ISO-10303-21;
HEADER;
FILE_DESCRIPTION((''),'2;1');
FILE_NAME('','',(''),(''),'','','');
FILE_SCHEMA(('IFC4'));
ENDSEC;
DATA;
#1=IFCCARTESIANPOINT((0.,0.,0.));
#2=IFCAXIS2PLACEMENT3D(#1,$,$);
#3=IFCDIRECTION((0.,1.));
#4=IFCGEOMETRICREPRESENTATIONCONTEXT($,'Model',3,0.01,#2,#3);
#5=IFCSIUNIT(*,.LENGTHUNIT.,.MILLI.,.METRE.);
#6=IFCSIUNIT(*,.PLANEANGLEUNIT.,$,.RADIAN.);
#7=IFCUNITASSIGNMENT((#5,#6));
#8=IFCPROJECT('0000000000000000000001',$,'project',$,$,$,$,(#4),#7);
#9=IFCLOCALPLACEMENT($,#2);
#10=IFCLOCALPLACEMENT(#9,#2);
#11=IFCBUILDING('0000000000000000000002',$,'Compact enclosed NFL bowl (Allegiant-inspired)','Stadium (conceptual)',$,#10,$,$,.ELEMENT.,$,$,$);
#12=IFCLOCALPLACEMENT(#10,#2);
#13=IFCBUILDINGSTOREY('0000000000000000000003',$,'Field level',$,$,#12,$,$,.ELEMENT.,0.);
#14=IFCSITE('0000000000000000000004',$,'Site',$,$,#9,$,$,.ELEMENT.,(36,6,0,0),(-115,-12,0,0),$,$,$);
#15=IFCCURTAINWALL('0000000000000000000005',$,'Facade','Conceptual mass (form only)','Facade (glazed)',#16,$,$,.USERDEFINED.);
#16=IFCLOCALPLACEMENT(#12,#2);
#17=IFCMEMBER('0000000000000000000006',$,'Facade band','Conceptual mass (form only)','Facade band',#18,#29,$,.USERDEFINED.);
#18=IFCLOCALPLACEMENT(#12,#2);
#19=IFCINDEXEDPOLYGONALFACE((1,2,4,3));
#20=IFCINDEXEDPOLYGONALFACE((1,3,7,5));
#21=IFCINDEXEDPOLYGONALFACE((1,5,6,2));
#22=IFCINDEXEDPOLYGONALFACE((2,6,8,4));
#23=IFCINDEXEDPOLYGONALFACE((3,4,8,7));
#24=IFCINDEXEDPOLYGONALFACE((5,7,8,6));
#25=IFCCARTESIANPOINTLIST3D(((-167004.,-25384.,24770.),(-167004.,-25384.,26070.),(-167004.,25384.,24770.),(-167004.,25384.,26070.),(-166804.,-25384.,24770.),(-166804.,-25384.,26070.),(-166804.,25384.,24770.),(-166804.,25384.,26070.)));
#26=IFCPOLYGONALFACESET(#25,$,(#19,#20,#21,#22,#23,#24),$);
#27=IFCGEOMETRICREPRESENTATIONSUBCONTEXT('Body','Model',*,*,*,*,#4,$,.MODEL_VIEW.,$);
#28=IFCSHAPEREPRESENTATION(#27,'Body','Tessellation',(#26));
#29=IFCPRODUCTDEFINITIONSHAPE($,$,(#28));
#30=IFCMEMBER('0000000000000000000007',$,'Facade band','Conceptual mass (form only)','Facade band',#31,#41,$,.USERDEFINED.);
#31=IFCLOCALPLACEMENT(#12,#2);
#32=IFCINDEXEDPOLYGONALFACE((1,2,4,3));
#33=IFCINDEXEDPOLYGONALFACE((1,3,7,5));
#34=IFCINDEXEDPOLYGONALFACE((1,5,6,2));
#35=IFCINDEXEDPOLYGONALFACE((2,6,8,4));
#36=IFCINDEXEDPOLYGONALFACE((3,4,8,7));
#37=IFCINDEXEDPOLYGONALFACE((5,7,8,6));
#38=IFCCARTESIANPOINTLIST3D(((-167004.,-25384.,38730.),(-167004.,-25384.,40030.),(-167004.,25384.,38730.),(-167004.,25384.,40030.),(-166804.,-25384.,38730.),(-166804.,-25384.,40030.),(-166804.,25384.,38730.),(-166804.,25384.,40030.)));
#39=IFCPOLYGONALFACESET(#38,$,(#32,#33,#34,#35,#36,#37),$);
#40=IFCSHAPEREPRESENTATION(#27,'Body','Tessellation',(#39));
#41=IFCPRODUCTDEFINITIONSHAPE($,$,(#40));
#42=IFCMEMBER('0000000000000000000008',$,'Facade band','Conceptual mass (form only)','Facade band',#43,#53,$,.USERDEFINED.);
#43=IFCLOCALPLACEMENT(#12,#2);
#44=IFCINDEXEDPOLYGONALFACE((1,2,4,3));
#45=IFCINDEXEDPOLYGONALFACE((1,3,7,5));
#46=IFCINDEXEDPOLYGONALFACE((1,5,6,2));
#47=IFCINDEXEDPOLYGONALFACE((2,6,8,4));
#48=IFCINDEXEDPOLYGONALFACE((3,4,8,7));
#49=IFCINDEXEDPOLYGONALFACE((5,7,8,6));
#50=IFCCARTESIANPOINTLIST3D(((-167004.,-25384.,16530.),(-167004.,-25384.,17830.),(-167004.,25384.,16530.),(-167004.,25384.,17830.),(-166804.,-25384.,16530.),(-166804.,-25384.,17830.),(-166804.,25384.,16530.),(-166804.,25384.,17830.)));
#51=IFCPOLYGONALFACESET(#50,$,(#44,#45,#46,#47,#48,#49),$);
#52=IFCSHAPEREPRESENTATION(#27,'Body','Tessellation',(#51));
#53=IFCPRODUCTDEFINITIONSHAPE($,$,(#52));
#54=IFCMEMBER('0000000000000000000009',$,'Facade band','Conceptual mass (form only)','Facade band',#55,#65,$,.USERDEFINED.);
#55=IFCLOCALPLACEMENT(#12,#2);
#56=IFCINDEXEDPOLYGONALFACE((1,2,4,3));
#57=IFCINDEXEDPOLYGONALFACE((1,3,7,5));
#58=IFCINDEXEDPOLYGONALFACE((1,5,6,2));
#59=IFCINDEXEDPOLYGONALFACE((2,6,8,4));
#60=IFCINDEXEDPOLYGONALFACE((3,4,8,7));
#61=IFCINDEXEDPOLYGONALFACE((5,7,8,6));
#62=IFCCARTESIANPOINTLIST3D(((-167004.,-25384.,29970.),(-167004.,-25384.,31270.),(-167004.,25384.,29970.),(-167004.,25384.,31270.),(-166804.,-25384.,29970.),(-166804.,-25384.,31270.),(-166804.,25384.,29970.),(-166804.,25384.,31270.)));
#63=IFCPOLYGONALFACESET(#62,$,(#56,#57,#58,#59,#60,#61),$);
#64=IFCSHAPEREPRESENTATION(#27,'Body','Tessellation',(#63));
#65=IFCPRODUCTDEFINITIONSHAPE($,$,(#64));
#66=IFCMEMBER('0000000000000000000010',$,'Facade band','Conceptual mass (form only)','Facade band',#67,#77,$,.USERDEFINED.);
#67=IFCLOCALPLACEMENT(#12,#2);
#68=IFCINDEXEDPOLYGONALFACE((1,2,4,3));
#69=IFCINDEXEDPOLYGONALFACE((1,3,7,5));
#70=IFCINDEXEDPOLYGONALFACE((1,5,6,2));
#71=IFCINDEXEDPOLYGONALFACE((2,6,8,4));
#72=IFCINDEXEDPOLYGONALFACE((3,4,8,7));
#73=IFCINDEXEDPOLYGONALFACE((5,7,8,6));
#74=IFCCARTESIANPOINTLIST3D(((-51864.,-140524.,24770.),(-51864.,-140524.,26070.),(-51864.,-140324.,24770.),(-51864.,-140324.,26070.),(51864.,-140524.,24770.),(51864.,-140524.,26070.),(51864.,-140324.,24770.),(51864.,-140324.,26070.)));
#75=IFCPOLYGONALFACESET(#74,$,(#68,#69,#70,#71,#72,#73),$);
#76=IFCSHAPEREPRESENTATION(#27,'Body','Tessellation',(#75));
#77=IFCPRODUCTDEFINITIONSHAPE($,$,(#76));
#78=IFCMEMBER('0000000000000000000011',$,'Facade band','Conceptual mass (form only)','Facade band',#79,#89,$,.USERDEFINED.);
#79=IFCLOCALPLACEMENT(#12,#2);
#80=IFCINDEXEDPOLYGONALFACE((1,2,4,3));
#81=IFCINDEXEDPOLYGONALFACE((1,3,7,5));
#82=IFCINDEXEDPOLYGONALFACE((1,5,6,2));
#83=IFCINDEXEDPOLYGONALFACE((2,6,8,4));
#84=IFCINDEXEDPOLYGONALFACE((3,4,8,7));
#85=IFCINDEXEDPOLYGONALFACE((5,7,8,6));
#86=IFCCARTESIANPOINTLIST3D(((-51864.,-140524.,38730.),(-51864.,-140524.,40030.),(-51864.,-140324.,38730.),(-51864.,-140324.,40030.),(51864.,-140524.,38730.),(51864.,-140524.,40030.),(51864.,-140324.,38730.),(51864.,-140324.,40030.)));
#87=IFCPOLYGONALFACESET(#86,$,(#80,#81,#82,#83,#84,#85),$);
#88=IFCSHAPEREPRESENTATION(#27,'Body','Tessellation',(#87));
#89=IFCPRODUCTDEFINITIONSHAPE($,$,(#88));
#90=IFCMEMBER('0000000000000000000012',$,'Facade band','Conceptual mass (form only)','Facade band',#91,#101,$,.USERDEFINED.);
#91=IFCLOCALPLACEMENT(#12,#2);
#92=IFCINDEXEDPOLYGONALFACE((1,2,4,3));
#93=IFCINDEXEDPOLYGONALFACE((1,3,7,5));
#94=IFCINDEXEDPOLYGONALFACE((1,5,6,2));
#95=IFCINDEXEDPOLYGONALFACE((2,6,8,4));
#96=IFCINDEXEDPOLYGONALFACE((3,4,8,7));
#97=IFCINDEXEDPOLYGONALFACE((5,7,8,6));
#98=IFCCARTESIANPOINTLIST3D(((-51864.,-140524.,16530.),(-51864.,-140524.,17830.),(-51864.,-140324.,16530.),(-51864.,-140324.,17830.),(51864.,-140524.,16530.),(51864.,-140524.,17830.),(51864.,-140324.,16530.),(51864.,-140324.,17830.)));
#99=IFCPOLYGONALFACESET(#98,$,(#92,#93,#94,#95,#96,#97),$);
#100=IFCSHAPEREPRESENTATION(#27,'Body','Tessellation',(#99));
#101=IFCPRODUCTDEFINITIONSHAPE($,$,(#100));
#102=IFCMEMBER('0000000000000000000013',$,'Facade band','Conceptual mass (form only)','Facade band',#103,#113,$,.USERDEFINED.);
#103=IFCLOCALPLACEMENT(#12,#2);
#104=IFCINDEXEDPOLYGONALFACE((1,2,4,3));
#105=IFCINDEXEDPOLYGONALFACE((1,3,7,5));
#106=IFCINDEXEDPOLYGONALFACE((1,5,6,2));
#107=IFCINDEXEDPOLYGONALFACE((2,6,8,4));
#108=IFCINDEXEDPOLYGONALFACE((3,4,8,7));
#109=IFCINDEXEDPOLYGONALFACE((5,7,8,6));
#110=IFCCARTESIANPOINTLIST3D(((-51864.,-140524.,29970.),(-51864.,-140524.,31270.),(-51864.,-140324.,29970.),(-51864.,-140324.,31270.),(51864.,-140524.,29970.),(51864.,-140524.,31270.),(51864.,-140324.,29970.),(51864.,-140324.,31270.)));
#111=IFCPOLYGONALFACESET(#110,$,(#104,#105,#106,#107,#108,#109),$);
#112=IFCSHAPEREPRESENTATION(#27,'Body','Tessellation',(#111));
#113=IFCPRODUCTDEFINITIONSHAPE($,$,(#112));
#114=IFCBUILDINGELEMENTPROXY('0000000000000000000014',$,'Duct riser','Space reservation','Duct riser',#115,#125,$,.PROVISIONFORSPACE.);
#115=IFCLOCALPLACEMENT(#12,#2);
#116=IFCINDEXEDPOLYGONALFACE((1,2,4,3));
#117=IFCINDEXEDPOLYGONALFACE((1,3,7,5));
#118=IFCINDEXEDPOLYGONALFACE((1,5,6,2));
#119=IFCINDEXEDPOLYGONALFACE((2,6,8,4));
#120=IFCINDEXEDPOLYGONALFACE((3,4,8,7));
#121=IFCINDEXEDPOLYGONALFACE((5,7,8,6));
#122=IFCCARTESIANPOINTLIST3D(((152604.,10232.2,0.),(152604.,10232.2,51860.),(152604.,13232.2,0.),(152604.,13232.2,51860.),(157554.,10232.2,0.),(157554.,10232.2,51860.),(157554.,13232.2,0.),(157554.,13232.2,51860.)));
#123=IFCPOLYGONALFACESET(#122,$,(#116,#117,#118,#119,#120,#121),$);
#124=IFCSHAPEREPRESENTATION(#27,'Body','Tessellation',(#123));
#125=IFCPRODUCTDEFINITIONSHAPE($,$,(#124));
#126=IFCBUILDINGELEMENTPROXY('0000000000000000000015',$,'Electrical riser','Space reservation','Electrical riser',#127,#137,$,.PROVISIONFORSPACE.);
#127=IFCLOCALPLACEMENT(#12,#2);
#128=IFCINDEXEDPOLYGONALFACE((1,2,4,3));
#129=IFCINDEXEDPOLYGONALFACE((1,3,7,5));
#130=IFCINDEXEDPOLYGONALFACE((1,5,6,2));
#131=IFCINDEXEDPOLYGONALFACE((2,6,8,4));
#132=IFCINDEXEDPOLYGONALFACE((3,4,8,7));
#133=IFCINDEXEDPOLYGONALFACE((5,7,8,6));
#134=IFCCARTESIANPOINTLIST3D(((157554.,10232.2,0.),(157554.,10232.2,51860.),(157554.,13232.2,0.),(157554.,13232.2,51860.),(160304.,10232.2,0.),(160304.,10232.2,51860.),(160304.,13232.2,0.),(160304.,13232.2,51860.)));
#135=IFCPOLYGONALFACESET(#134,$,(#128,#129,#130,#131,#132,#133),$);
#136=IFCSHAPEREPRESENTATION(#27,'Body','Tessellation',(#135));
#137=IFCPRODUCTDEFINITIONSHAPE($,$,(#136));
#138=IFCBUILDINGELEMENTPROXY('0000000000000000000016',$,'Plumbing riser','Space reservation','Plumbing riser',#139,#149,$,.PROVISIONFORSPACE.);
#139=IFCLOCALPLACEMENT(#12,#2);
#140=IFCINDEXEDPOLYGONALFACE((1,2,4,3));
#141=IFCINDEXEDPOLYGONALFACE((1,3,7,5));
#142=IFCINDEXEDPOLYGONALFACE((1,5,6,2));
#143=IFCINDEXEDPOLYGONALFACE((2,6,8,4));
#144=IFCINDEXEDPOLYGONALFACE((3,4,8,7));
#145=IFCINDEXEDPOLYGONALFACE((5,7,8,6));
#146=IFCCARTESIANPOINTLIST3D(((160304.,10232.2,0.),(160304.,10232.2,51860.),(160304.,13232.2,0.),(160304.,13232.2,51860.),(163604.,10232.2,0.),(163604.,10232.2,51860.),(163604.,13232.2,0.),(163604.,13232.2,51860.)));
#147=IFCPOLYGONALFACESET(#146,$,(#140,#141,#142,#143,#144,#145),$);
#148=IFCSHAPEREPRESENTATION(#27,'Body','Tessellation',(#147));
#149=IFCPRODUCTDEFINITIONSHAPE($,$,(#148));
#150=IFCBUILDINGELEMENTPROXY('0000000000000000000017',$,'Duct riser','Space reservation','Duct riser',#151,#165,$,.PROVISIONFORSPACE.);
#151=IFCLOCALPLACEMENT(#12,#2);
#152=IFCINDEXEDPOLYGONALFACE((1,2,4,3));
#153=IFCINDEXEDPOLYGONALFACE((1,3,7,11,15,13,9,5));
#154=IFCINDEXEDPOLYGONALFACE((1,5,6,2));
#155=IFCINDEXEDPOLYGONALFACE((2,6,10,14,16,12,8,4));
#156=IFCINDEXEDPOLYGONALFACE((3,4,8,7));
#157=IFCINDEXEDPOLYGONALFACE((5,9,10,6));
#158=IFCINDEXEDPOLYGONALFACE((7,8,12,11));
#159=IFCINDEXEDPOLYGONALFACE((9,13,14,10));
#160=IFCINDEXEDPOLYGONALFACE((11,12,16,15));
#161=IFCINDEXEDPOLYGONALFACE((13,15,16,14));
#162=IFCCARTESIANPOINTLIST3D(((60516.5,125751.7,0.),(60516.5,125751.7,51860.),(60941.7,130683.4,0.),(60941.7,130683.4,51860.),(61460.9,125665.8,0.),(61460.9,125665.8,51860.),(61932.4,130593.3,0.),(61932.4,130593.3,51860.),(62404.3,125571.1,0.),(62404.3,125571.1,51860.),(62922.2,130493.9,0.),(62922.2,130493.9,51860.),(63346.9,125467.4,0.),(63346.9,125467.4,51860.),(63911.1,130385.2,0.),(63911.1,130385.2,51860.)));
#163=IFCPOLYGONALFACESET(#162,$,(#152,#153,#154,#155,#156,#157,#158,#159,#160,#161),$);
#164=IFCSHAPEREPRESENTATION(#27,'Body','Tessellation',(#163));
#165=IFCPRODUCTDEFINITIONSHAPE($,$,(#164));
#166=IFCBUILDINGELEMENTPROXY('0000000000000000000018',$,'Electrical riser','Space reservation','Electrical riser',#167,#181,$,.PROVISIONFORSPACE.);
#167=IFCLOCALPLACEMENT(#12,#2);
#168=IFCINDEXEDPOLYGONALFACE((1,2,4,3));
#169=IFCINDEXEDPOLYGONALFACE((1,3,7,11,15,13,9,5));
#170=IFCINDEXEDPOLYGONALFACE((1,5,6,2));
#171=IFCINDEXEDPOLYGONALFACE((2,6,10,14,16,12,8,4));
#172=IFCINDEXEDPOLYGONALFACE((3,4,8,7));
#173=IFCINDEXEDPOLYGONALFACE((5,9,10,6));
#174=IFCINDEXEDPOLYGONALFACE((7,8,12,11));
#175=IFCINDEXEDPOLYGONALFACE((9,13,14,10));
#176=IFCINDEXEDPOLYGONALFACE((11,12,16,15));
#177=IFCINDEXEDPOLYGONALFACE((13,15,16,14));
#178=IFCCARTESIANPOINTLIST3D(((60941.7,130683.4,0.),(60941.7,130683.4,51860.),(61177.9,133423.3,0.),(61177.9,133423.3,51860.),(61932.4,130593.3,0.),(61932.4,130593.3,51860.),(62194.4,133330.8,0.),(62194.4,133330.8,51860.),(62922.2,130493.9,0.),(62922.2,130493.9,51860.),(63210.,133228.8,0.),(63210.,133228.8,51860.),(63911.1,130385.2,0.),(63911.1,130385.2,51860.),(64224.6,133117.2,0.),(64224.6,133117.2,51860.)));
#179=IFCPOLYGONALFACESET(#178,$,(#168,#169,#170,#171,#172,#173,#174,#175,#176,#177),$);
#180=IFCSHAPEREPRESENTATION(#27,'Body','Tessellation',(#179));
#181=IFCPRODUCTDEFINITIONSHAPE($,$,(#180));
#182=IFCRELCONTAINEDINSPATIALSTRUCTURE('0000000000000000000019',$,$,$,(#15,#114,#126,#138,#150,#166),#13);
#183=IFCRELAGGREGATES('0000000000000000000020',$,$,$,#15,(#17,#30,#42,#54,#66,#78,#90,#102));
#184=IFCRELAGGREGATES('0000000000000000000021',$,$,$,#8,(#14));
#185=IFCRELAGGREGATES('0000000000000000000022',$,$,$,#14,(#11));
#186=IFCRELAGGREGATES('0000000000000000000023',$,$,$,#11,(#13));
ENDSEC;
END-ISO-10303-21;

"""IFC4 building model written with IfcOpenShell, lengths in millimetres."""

from ifc_helpers import new_model, si_unit, direction, frame, origin, place, context, subcontext, project, spatial, line, arc, indexed_curve, outline, extrude, element, aggregate, save


model = new_model("IFC4")

# Units and contexts
model_context = context("Model", 3, precision=0.01, world=origin(), true_north=direction((0.0, 1.0)))
body_context = subcontext(model_context, "Body", "Model", "MODEL_VIEW")
ifc_project = project(units=[si_unit("LENGTHUNIT", "METRE", prefix="MILLI"), si_unit("PLANEANGLEUNIT", "RADIAN")], contexts=[model_context])

# Site, building, storey
site_placement = place(None, origin())
site = spatial("IfcSite", under=ifc_project, at=site_placement, Name="Site", CompositionType="ELEMENT", RefLatitude=(36, 6, 0, 0), RefLongitude=(-115, -12, 0, 0))
building_placement = place(site_placement, origin())
building = spatial("IfcBuilding", under=site, at=building_placement, Name="Compact enclosed NFL bowl (Allegiant-inspired)", Description="Stadium (conceptual)", CompositionType="ELEMENT")
storey_placement = place(building_placement, origin())
storey = spatial("IfcBuildingStorey", under=building, at=storey_placement, Name="Field level", CompositionType="ELEMENT", Elevation=0.0)

# Curtain wall, members
placement_1 = place(storey_placement, origin())
curtain_wall = element("IfcCurtainWall", 1, at=placement_1, inside=storey, Name="Facade", Description="Conceptual mass (form only)", ObjectType="Facade (glazed)", PredefinedType="USERDEFINED")
placement_2 = place(building_placement, frame((0.0, 0.0, 25770.0)))
placement_3 = place(placement_2, frame((0.0, 0.0, -25770.0)))
placement_4 = place(building_placement, frame((0.0, 0.0, 17530.0)))
placement_5 = place(placement_4, frame((0.0, 0.0, -17530.0)))
member_1 = element("IfcMember", 2, at=placement_5, Name="Facade band", Description="Conceptual mass (form only)", ObjectType="Facade band", PredefinedType="USERDEFINED", context=body_context, shape_type="SweptSolid", body=[
    extrude(outline(indexed_curve([(-166804.0, 25384.0), (-166804.0, -25384.0), (-167004.0, -25384.0), (-167004.0, 25384.0)], segments=[line(1, 2), line(2, 3), line(3, 4), line(4, 1)], self_intersect=False)), frame((0.0, 0.0, 24770.0)), (0.0, 0.0, 1.0), 1300.0),
])
placement_6 = place(building_placement, frame((0.0, 0.0, 30970.0)))
placement_7 = place(placement_6, frame((0.0, 0.0, -30970.0)))
member_2 = element("IfcMember", 3, at=placement_7, Name="Facade band", Description="Conceptual mass (form only)", ObjectType="Facade band", PredefinedType="USERDEFINED", context=body_context, shape_type="SweptSolid", body=[
    extrude(outline(indexed_curve([(-166804.0, 25384.0), (-166804.0, -25384.0), (-167004.0, -25384.0), (-167004.0, 25384.0)], segments=[line(1, 2), line(2, 3), line(3, 4), line(4, 1)], self_intersect=False)), frame((0.0, 0.0, 38730.0)), (0.0, 0.0, 1.0), 1300.0),
])
placement_8 = place(building_placement, frame((0.0, 0.0, 5510.0)))
placement_9 = place(placement_8, frame((0.0, 0.0, -5510.0)))
member_3 = element("IfcMember", 4, at=placement_9, Name="Facade band", Description="Conceptual mass (form only)", ObjectType="Facade band", PredefinedType="USERDEFINED", context=body_context, shape_type="SweptSolid", body=[
    extrude(outline(indexed_curve([(-166804.0, 25384.0), (-166804.0, -25384.0), (-167004.0, -25384.0), (-167004.0, 25384.0)], segments=[line(1, 2), line(2, 3), line(3, 4), line(4, 1)], self_intersect=False)), frame((0.0, 0.0, 16530.0)), (0.0, 0.0, 1.0), 1300.0),
])
member_4 = element("IfcMember", 5, at=placement_3, Name="Facade band", Description="Conceptual mass (form only)", ObjectType="Facade band", PredefinedType="USERDEFINED", context=body_context, shape_type="SweptSolid", body=[
    extrude(outline(indexed_curve([(-166804.0, 25384.0), (-166804.0, -25384.0), (-167004.0, -25384.0), (-167004.0, 25384.0)], segments=[line(1, 2), line(2, 3), line(3, 4), line(4, 1)], self_intersect=False)), frame((0.0, 0.0, 29970.0)), (0.0, 0.0, 1.0), 1300.0),
])
member_5 = element("IfcMember", 6, at=placement_5, Name="Facade band", Description="Conceptual mass (form only)", ObjectType="Facade band", PredefinedType="USERDEFINED", context=body_context, shape_type="SweptSolid", body=[
    extrude(outline(indexed_curve([(-51864.0, -140324.0), (51864.0, -140324.0), (51864.0, -140524.0), (-51864.0, -140524.0)], segments=[line(1, 2), line(2, 3), line(3, 4), line(4, 1)], self_intersect=False)), frame((0.0, 0.0, 24770.0)), (0.0, 0.0, 1.0), 1300.0),
])
member_6 = element("IfcMember", 7, at=placement_7, Name="Facade band", Description="Conceptual mass (form only)", ObjectType="Facade band", PredefinedType="USERDEFINED", context=body_context, shape_type="SweptSolid", body=[
    extrude(outline(indexed_curve([(-51864.0, -140324.0), (51864.0, -140324.0), (51864.0, -140524.0), (-51864.0, -140524.0)], segments=[line(1, 2), line(2, 3), line(3, 4), line(4, 1)], self_intersect=False)), frame((0.0, 0.0, 38730.0)), (0.0, 0.0, 1.0), 1300.0),
])
member_7 = element("IfcMember", 8, at=placement_9, Name="Facade band", Description="Conceptual mass (form only)", ObjectType="Facade band", PredefinedType="USERDEFINED", context=body_context, shape_type="SweptSolid", body=[
    extrude(outline(indexed_curve([(-51864.0, -140324.0), (51864.0, -140324.0), (51864.0, -140524.0), (-51864.0, -140524.0)], segments=[line(1, 2), line(2, 3), line(3, 4), line(4, 1)], self_intersect=False)), frame((0.0, 0.0, 16530.0)), (0.0, 0.0, 1.0), 1300.0),
])
member_8 = element("IfcMember", 9, at=placement_3, Name="Facade band", Description="Conceptual mass (form only)", ObjectType="Facade band", PredefinedType="USERDEFINED", context=body_context, shape_type="SweptSolid", body=[
    extrude(outline(indexed_curve([(-51864.0, -140324.0), (51864.0, -140324.0), (51864.0, -140524.0), (-51864.0, -140524.0)], segments=[line(1, 2), line(2, 3), line(3, 4), line(4, 1)], self_intersect=False)), frame((0.0, 0.0, 29970.0)), (0.0, 0.0, 1.0), 1300.0),
])
aggregate(curtain_wall, [member_1, member_2, member_3, member_4, member_5, member_6, member_7, member_8])

# Building element proxies
element("IfcBuildingElementProxy", 10, at=placement_1, inside=storey, Name="Duct riser", Description="Space reservation", ObjectType="Duct riser", PredefinedType="PROVISIONFORSPACE", context=body_context, shape_type="SweptSolid", body=[
    extrude(outline(indexed_curve([(152604.0, 10232.2), (152604.0, 13232.2), (157554.0, 13232.2), (157554.0, 10232.2)], segments=[line(1, 2), line(2, 3), line(3, 4), line(4, 1)], self_intersect=False)), origin(), (0.0, 0.0, 1.0), 51860.0),
])
element("IfcBuildingElementProxy", 11, at=placement_1, inside=storey, Name="Electrical riser", Description="Space reservation", ObjectType="Electrical riser", PredefinedType="PROVISIONFORSPACE", context=body_context, shape_type="SweptSolid", body=[
    extrude(outline(indexed_curve([(157554.0, 10232.2), (157554.0, 13232.2), (160304.0, 13232.2), (160304.0, 10232.2)], segments=[line(1, 2), line(2, 3), line(3, 4), line(4, 1)], self_intersect=False)), origin(), (0.0, 0.0, 1.0), 51860.0),
])
element("IfcBuildingElementProxy", 12, at=placement_1, inside=storey, Name="Plumbing riser", Description="Space reservation", ObjectType="Plumbing riser", PredefinedType="PROVISIONFORSPACE", context=body_context, shape_type="SweptSolid", body=[
    extrude(outline(indexed_curve([(160304.0, 10232.2), (160304.0, 13232.2), (163604.0, 13232.2), (163604.0, 10232.2)], segments=[line(1, 2), line(2, 3), line(3, 4), line(4, 1)], self_intersect=False)), origin(), (0.0, 0.0, 1.0), 51860.0),
])
element("IfcBuildingElementProxy", 13, at=placement_1, inside=storey, Name="Duct riser", Description="Space reservation", ObjectType="Duct riser", PredefinedType="PROVISIONFORSPACE", context=body_context, shape_type="SweptSolid", body=[
    extrude(outline(indexed_curve([(63346.9, 125467.4), (61932.7, 125619.6), (60516.5, 125751.7), (60941.7, 130683.4), (62427.4, 130544.8), (63911.1, 130385.2)], segments=[arc(1, 2, 3), line(3, 4), arc(4, 5, 6), line(6, 1)], self_intersect=False)), origin(), (0.0, 0.0, 1.0), 51860.0),
])
element("IfcBuildingElementProxy", 14, at=placement_1, inside=storey, Name="Electrical riser", Description="Space reservation", ObjectType="Electrical riser", PredefinedType="PROVISIONFORSPACE", context=body_context, shape_type="SweptSolid", body=[
    extrude(outline(indexed_curve([(63911.1, 130385.2), (62427.4, 130544.8), (60941.7, 130683.4), (61177.9, 133423.3), (62702.3, 133281.0), (64224.6, 133117.2)], segments=[arc(1, 2, 3), line(3, 4), arc(4, 5, 6), line(6, 1)], self_intersect=False)), origin(), (0.0, 0.0, 1.0), 51860.0),
])

save(model, "model.ifc")
